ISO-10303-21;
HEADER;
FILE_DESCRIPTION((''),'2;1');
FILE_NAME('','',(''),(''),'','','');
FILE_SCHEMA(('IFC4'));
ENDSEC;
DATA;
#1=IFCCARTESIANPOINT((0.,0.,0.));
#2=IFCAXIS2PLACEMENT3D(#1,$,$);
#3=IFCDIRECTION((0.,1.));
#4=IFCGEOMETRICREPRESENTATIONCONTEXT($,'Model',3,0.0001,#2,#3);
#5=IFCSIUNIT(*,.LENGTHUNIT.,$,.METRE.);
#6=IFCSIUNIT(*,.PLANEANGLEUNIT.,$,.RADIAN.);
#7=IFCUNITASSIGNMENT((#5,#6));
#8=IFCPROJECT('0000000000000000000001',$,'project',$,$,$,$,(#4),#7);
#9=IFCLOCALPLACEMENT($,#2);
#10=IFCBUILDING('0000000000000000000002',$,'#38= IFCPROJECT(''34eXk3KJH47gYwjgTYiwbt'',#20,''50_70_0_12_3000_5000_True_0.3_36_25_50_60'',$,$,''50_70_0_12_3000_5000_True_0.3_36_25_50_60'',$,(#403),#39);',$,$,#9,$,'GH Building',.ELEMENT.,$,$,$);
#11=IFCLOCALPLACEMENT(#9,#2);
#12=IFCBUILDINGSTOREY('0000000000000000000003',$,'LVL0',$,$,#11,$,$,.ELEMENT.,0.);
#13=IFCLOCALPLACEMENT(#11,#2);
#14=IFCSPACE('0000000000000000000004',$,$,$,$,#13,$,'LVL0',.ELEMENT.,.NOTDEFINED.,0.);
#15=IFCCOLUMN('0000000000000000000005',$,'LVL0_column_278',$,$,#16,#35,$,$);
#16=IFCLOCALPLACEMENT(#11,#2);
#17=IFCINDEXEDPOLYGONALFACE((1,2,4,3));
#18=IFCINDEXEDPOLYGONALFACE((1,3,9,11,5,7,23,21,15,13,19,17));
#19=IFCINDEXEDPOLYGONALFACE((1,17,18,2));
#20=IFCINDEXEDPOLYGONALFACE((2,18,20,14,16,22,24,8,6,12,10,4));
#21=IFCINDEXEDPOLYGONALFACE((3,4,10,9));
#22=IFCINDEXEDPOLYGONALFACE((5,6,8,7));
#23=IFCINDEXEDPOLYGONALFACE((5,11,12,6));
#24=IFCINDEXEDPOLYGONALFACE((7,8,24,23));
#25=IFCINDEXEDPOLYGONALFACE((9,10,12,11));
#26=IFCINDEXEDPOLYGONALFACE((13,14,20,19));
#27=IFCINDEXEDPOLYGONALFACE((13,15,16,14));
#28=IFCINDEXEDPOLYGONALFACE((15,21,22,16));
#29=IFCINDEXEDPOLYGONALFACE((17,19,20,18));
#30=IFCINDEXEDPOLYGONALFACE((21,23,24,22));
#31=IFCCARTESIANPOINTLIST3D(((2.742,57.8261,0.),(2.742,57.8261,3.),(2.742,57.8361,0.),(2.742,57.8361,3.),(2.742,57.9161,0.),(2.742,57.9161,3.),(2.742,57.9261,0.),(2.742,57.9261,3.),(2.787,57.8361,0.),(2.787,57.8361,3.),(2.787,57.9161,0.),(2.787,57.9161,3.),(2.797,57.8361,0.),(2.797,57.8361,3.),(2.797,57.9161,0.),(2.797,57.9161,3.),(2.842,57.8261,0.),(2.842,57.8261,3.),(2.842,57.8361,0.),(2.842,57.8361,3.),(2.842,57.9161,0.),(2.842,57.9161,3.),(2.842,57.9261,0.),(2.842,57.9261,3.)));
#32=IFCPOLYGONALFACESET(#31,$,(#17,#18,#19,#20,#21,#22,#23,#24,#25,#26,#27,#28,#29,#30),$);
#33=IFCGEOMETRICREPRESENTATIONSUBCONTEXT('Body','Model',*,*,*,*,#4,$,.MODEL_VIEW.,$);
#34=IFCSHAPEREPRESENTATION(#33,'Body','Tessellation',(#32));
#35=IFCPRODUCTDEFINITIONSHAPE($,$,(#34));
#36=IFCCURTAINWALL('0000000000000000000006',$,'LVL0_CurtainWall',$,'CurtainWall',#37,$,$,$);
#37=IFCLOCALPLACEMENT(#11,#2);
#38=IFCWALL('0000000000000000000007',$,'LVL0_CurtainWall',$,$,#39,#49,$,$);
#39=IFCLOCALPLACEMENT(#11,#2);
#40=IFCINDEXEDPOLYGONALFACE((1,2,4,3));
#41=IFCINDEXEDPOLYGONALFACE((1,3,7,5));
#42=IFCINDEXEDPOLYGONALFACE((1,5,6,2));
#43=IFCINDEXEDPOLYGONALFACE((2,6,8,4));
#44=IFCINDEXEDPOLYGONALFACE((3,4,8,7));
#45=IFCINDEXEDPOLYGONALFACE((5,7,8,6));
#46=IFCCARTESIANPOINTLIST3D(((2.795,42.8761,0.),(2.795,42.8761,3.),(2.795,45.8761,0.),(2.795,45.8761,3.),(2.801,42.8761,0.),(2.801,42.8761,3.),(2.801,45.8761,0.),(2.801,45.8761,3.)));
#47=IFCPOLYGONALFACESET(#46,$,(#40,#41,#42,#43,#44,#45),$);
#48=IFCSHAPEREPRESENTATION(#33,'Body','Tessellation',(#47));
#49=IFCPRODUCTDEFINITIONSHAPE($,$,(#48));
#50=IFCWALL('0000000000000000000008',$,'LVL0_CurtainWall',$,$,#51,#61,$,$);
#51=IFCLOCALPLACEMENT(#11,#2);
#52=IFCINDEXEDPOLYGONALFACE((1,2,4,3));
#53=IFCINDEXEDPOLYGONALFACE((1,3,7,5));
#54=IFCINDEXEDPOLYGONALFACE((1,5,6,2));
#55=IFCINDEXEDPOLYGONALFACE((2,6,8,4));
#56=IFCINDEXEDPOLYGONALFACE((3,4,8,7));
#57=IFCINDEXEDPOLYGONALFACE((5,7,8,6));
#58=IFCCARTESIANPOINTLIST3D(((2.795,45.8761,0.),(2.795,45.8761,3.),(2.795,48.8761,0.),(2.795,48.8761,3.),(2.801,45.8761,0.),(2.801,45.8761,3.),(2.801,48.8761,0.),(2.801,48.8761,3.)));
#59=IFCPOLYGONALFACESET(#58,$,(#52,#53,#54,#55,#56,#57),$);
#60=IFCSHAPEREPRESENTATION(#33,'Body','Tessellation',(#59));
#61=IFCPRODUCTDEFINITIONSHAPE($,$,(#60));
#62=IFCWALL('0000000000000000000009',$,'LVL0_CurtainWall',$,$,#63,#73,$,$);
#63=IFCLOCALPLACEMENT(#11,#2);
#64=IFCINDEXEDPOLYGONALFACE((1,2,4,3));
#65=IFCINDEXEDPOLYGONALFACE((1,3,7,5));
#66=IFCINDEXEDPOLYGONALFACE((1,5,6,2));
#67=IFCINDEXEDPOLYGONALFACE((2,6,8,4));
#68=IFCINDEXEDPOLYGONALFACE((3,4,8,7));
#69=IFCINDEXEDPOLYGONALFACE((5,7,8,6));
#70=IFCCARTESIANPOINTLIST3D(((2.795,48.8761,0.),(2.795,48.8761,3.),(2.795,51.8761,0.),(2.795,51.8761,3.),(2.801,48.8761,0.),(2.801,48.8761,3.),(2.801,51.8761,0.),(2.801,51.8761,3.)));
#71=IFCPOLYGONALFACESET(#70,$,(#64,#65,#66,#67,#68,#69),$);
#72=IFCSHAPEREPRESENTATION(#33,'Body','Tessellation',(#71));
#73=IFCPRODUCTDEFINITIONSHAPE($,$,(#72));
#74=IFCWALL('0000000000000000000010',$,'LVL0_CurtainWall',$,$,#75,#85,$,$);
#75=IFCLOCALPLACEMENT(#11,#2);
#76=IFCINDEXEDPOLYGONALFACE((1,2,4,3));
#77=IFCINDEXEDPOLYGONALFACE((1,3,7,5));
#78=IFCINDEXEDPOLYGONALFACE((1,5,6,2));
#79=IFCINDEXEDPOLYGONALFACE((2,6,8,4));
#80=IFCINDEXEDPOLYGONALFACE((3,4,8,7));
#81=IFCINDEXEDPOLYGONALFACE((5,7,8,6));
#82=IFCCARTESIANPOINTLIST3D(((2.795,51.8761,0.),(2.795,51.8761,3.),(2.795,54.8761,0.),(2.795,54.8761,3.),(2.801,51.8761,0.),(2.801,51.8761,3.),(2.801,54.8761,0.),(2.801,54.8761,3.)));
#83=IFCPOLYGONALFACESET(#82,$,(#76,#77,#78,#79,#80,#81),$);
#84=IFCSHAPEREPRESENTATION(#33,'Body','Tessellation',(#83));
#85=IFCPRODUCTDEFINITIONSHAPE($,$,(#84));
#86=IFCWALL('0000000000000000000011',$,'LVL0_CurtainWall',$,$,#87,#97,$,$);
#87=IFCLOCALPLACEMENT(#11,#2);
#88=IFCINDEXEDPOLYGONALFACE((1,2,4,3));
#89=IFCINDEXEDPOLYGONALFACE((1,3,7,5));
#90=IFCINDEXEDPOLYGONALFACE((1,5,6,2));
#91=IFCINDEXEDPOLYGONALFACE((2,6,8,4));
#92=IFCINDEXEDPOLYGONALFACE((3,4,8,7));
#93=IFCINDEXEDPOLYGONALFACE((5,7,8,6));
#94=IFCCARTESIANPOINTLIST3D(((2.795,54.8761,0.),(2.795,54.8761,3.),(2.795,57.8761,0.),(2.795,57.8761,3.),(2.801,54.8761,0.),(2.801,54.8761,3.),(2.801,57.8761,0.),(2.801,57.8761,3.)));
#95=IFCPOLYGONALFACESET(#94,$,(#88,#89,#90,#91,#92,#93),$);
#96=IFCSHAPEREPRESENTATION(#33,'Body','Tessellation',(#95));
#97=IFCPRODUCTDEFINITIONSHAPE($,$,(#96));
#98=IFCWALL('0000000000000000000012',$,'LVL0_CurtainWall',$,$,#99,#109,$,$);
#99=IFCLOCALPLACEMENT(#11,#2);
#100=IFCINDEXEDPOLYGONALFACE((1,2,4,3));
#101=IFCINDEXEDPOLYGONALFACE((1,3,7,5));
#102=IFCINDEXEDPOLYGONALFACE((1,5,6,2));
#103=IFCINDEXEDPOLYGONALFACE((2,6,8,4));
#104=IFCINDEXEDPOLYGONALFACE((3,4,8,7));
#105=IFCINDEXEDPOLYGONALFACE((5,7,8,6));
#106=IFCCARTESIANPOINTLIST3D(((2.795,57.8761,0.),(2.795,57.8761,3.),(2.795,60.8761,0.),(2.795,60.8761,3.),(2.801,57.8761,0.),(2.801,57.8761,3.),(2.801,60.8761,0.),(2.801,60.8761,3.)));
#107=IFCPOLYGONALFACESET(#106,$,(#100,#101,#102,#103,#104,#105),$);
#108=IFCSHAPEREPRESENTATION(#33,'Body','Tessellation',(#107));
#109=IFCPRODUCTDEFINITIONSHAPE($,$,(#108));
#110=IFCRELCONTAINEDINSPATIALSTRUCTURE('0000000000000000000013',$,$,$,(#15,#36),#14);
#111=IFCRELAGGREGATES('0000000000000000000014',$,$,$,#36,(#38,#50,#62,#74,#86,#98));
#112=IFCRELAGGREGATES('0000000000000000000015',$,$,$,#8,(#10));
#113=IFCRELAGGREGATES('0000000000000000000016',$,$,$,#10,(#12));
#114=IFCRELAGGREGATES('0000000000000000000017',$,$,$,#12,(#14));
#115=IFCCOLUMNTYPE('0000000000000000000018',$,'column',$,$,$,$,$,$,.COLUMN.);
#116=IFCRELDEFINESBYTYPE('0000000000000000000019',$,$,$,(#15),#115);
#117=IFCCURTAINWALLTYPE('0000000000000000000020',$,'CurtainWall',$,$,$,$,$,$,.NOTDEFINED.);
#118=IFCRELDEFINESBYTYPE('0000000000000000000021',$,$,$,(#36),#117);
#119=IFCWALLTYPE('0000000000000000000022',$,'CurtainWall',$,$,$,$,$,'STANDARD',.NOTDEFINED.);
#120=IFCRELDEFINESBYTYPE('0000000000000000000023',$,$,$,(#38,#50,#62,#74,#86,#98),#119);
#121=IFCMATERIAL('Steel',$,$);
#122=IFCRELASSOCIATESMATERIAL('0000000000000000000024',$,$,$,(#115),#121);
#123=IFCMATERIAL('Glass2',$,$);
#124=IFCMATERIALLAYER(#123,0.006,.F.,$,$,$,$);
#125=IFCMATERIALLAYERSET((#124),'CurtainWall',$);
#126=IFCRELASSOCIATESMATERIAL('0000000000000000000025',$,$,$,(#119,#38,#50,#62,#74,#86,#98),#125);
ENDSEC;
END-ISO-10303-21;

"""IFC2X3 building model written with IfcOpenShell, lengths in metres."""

from ifc_helpers import new_model, si_unit, direction, frame, frame_2d, origin, origin_2d, place, context, subcontext, project, spatial, rectangle, i_section, extrude, material, layer, layer_set, layer_usage, type_object, element, aggregate, save


model = new_model("IFC2X3")

# Units and contexts
model_context = context("Model", 3, precision=0.0001, world=origin(), true_north=direction((0.0, 1.0)))
body_context = subcontext(model_context, "Body", "Model", "MODEL_VIEW")
ifc_project = project(units=[si_unit("LENGTHUNIT", "METRE"), si_unit("PLANEANGLEUNIT", "RADIAN")], contexts=[model_context])

# Building, storey, space
building_placement = place(None, origin())
building = spatial("IfcBuilding", under=ifc_project, at=building_placement, Name="#38= IFCPROJECT('34eXk3KJH47gYwjgTYiwbt',#20,'50_70_0_12_3000_5000_True_0.3_36_25_50_60',$,$,'50_70_0_12_3000_5000_True_0.3_36_25_50_60',$,(#403),#39);", LongName="GH Building", CompositionType="ELEMENT")
storey_placement = place(building_placement, origin())
storey = spatial("IfcBuildingStorey", under=building, at=storey_placement, Name="LVL0", CompositionType="ELEMENT", Elevation=0.0)
space_placement = place(storey_placement, origin())
space = spatial("IfcSpace", under=storey, at=space_placement, LongName="LVL0", CompositionType="ELEMENT", InteriorOrExteriorSpace="NOTDEFINED", ElevationWithFlooring=0.0)

# Column
ifc_material_1 = material(Name="Steel")
column_type = type_object("IfcColumnType", Name="column", PredefinedType="COLUMN", material=ifc_material_1)
for number, where, name in (
    (1, (2.792, 57.8761, 0.0), "LVL0_column_278"),
):
    element("IfcColumn", number, at=place(space_placement, frame(where)), inside=space, type_object=column_type, Name=name, context=body_context, shape_type="SweptSolid", body=[
        extrude(i_section(OverallWidth=0.1, OverallDepth=0.1, WebThickness=0.01, FlangeThickness=0.01, at=origin_2d()), origin(), (0.0, 0.0, 1.0), 3.0),
    ])

# Curtain wall, walls
curtain_wall_type = type_object("IfcCurtainWallType", Name="CurtainWall", PredefinedType="NOTDEFINED")
curtain_wall_placement = place(None, origin())
curtain_wall = element("IfcCurtainWall", 2, at=curtain_wall_placement, inside=space, type_object=curtain_wall_type, Name="LVL0_CurtainWall", ObjectType="CurtainWall")
ifc_material_2 = material(Name="Glass2")
ifc_layer = layer(ifc_material_2, 0.006, ventilated=False)
ifc_layer_set = layer_set([ifc_layer], Name="CurtainWall")
ifc_layer_usage_1 = layer_usage(ifc_layer_set, "AXIS2", "NEGATIVE", -0.003)
wall_type = type_object("IfcWallType", Name="CurtainWall", ElementType="STANDARD", PredefinedType="NOTDEFINED", material=ifc_layer_set)
wall_1_placement = place(curtain_wall_placement, frame((2.792, 42.8761, 0.0), z_axis=(0.0, 0.0, 1.0), x_axis=(0.0, 1.0, 0.0)))
wall_1 = element("IfcWall", 3, at=wall_1_placement, type_object=wall_type, material=ifc_layer_usage_1, Name="LVL0_CurtainWall", context=body_context, shape_type="SweptSolid", body=[
    extrude(rectangle(XDim=3.0, YDim=0.006, at=frame_2d((1.5, -0.006))), origin(), (0.0, 0.0, 1.0), 3.0),
])
ifc_layer_usage_2 = layer_usage(ifc_layer_set, "AXIS2", "NEGATIVE", -0.003)
wall_2_placement = place(curtain_wall_placement, frame((2.792, 45.8761, 0.0), z_axis=(0.0, 0.0, 1.0), x_axis=(0.0, 1.0, 0.0)))
wall_2 = element("IfcWall", 4, at=wall_2_placement, type_object=wall_type, material=ifc_layer_usage_2, Name="LVL0_CurtainWall", context=body_context, shape_type="SweptSolid", body=[
    extrude(rectangle(XDim=3.0, YDim=0.006, at=frame_2d((1.5, -0.006))), origin(), (0.0, 0.0, 1.0), 3.0),
])
ifc_layer_usage_3 = layer_usage(ifc_layer_set, "AXIS2", "NEGATIVE", -0.003)
wall_3_placement = place(curtain_wall_placement, frame((2.792, 48.8761, 0.0), z_axis=(0.0, 0.0, 1.0), x_axis=(0.0, 1.0, 0.0)))
wall_3 = element("IfcWall", 5, at=wall_3_placement, type_object=wall_type, material=ifc_layer_usage_3, Name="LVL0_CurtainWall", context=body_context, shape_type="SweptSolid", body=[
    extrude(rectangle(XDim=3.0, YDim=0.006, at=frame_2d((1.5, -0.006))), origin(), (0.0, 0.0, 1.0), 3.0),
])
ifc_layer_usage_4 = layer_usage(ifc_layer_set, "AXIS2", "NEGATIVE", -0.003)
wall_4_placement = place(curtain_wall_placement, frame((2.792, 51.8761, 0.0), z_axis=(0.0, 0.0, 1.0), x_axis=(0.0, 1.0, 0.0)))
wall_4 = element("IfcWall", 6, at=wall_4_placement, type_object=wall_type, material=ifc_layer_usage_4, Name="LVL0_CurtainWall", context=body_context, shape_type="SweptSolid", body=[
    extrude(rectangle(XDim=3.0, YDim=0.006, at=frame_2d((1.5, -0.006))), origin(), (0.0, 0.0, 1.0), 3.0),
])
ifc_layer_usage_5 = layer_usage(ifc_layer_set, "AXIS2", "NEGATIVE", -0.003)
wall_5_placement = place(curtain_wall_placement, frame((2.792, 54.8761, 0.0), z_axis=(0.0, 0.0, 1.0), x_axis=(0.0, 1.0, 0.0)))
wall_5 = element("IfcWall", 7, at=wall_5_placement, type_object=wall_type, material=ifc_layer_usage_5, Name="LVL0_CurtainWall", context=body_context, shape_type="SweptSolid", body=[
    extrude(rectangle(XDim=3.0, YDim=0.006, at=frame_2d((1.5, -0.006))), origin(), (0.0, 0.0, 1.0), 3.0),
])
ifc_layer_usage_6 = layer_usage(ifc_layer_set, "AXIS2", "NEGATIVE", -0.003)
wall_6_placement = place(curtain_wall_placement, frame((2.792, 57.8761, 0.0), z_axis=(0.0, 0.0, 1.0), x_axis=(0.0, 1.0, 0.0)))
wall_6 = element("IfcWall", 8, at=wall_6_placement, type_object=wall_type, material=ifc_layer_usage_6, Name="LVL0_CurtainWall", context=body_context, shape_type="SweptSolid", body=[
    extrude(rectangle(XDim=3.0, YDim=0.006, at=frame_2d((1.5, -0.006))), origin(), (0.0, 0.0, 1.0), 3.0),
])
aggregate(curtain_wall, [wall_1, wall_2, wall_3, wall_4, wall_5, wall_6])

save(model, "model.ifc")
